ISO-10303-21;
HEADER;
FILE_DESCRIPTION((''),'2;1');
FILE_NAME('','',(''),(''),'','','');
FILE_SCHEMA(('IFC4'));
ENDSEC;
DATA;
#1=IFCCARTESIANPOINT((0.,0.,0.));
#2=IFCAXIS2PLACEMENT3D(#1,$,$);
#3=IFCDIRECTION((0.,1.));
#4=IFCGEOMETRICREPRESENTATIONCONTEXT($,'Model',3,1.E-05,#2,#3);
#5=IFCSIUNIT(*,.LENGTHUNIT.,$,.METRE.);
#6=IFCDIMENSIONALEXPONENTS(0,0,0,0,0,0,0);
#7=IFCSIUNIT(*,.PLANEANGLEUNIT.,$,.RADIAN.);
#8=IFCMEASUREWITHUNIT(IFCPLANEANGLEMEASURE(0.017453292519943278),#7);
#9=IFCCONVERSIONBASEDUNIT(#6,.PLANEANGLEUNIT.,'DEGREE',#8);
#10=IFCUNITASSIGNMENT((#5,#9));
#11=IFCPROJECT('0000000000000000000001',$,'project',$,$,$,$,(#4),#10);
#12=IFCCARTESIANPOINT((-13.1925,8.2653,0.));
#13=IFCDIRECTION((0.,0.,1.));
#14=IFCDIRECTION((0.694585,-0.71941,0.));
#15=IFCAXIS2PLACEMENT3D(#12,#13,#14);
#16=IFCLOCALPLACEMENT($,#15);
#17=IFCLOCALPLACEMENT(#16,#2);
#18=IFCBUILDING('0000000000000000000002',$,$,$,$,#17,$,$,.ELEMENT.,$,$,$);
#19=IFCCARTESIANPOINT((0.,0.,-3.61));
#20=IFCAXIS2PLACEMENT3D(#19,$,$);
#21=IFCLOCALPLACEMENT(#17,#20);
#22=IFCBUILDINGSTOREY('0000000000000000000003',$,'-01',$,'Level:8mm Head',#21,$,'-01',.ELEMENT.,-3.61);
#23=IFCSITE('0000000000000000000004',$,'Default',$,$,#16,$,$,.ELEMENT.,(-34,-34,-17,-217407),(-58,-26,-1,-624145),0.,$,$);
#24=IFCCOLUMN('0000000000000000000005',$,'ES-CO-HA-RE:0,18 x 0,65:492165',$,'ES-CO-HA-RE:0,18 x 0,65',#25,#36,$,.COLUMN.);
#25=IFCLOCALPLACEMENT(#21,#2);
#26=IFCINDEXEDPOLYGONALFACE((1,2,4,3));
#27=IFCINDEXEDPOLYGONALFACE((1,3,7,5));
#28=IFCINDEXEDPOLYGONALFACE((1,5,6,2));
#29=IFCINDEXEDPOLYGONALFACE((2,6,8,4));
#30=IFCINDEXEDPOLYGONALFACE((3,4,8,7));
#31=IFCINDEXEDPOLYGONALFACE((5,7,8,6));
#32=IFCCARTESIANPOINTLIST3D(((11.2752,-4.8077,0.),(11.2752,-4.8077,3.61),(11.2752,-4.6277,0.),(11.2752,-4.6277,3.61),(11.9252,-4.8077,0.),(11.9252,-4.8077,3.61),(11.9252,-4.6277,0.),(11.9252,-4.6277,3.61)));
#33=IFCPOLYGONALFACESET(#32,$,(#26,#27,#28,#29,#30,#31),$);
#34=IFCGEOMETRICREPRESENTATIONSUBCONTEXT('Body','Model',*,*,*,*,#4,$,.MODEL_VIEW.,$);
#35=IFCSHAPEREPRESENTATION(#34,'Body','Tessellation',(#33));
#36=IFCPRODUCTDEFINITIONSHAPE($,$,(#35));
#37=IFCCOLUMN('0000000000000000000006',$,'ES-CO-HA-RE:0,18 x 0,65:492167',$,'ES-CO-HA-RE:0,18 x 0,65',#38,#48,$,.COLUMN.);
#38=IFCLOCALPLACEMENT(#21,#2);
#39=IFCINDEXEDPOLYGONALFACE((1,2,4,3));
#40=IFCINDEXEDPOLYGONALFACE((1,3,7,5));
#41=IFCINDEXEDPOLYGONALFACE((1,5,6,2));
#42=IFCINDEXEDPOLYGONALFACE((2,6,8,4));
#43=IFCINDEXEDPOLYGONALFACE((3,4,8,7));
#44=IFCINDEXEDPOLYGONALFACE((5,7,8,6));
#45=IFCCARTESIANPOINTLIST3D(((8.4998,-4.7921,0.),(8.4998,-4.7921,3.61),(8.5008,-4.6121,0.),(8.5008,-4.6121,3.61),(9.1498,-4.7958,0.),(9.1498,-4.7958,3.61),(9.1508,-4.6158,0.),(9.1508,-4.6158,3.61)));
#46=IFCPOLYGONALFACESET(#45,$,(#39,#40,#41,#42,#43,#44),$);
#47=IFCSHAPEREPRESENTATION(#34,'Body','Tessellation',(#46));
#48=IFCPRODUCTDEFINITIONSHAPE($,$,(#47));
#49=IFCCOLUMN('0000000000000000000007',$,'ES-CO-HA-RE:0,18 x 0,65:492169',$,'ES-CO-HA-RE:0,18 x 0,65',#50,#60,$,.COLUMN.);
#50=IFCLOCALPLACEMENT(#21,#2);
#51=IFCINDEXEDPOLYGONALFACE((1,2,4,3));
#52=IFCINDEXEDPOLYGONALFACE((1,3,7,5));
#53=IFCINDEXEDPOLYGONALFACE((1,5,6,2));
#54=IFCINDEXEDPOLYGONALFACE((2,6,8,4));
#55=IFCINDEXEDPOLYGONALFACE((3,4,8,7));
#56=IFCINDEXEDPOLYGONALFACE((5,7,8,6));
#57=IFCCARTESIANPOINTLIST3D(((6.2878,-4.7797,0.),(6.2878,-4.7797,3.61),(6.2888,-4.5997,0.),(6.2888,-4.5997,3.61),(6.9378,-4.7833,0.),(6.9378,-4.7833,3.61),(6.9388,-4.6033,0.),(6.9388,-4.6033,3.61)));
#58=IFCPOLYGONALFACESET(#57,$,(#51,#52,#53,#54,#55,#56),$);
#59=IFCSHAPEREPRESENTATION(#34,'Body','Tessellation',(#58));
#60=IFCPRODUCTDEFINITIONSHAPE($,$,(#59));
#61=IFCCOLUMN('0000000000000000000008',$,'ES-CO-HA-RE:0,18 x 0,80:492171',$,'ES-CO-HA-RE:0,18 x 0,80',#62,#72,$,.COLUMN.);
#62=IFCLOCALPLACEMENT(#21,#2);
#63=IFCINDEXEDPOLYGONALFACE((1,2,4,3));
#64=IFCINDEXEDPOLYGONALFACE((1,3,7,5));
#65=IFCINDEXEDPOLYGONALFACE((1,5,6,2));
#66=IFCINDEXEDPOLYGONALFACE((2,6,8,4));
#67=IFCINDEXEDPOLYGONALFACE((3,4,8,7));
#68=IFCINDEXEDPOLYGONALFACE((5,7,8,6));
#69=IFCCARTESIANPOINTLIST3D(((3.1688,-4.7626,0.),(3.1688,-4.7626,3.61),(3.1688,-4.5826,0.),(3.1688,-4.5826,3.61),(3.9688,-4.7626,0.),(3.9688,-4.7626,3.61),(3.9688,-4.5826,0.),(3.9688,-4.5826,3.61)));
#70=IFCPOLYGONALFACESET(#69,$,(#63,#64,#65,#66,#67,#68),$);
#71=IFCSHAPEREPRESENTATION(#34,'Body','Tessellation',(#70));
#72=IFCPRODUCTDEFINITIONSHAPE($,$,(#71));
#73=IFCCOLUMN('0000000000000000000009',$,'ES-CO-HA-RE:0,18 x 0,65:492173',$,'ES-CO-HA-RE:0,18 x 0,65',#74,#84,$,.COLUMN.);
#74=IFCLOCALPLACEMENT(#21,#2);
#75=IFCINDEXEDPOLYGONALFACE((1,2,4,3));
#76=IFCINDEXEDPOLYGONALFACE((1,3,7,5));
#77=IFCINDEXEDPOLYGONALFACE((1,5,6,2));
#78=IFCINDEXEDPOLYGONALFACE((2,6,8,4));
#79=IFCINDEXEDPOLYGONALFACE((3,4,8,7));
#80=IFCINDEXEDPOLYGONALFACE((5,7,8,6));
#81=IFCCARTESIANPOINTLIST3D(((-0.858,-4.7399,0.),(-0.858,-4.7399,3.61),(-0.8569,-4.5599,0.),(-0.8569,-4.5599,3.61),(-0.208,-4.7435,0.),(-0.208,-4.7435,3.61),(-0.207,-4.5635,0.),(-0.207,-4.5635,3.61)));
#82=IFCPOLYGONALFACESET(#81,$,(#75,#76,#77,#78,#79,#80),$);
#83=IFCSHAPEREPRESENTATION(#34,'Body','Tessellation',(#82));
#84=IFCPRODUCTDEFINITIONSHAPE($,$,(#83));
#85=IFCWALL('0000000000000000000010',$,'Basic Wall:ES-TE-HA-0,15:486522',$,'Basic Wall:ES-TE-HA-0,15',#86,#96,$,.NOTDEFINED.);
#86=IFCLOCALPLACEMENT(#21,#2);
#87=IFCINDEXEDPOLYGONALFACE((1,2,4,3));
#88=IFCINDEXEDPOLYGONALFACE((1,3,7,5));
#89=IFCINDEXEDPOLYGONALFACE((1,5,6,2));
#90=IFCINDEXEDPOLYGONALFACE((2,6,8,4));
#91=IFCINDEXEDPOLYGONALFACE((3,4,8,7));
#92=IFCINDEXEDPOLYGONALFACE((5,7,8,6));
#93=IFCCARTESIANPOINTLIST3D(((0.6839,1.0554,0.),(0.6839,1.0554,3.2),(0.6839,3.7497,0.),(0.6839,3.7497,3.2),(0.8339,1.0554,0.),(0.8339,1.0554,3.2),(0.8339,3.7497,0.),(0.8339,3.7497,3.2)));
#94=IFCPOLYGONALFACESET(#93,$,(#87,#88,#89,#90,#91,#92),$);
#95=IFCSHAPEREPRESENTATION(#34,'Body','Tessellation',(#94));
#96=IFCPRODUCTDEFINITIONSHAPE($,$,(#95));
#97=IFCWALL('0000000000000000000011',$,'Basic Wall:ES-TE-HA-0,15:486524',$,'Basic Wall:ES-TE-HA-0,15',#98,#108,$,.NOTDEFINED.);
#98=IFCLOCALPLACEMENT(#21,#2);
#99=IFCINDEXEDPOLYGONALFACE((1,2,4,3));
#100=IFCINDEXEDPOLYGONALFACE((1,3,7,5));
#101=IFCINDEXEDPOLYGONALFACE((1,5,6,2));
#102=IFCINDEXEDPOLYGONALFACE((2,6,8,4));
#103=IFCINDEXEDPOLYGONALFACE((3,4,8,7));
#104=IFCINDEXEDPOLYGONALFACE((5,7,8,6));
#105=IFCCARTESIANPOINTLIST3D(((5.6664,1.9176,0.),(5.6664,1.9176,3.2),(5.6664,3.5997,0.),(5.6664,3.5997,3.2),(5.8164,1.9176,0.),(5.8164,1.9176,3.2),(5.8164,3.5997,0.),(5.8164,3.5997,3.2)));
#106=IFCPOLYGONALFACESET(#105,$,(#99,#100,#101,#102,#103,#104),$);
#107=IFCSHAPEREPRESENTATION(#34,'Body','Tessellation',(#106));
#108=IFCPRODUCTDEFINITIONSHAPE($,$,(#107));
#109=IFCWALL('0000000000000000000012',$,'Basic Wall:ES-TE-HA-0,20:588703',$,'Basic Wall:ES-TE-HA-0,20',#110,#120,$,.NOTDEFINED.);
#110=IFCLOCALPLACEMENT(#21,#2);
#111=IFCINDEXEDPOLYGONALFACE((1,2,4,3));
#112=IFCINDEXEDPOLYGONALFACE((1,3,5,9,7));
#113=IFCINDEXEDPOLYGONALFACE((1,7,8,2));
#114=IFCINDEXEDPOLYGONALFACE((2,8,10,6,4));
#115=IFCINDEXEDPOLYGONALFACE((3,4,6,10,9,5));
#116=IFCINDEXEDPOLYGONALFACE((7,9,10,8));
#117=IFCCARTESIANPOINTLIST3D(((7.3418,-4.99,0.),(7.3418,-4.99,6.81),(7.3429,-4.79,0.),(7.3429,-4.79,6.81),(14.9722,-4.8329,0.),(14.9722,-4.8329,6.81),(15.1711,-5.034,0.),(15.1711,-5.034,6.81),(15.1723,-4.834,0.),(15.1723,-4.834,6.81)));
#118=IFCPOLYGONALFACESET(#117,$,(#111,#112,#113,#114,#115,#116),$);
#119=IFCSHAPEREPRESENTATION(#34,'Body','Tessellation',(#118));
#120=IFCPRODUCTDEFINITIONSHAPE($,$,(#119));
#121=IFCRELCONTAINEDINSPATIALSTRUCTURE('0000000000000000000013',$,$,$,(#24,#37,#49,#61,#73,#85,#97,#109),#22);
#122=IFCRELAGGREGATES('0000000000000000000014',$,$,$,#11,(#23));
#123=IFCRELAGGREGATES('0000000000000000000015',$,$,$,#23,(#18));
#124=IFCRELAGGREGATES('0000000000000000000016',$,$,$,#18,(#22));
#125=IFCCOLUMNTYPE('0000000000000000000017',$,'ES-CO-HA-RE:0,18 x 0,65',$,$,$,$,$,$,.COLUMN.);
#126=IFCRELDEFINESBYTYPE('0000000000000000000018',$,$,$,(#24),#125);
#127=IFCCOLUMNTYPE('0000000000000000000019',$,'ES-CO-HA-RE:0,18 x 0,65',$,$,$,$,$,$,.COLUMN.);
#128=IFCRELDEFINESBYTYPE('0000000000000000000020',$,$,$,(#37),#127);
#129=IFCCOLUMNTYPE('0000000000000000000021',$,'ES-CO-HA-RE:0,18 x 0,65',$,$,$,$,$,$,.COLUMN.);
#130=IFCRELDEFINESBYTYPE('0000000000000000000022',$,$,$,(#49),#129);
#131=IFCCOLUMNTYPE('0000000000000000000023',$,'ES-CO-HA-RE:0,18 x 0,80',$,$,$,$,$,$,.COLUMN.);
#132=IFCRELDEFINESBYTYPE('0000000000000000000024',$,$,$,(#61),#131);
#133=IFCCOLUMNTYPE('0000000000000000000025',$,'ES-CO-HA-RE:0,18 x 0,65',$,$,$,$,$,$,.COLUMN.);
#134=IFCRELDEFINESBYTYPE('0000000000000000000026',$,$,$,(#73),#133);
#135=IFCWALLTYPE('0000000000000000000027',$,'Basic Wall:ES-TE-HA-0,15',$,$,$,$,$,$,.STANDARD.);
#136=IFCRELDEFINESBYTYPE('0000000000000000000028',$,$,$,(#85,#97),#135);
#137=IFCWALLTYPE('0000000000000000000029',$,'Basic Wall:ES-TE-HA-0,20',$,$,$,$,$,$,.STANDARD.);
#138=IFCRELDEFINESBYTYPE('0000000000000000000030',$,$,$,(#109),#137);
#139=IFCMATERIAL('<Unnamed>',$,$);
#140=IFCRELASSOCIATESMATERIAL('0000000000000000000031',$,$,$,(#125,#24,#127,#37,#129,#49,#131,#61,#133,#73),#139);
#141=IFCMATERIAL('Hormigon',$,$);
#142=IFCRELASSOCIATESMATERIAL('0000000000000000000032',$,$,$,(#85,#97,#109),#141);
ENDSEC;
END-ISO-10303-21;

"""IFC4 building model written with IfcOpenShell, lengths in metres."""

from ifc_helpers import new_model, entity, si_unit, converted_unit, direction, frame, origin, place, context, subcontext, project, spatial, indexed_curve, outline, extrude, source, transform, mapped, material, type_object, type_shapes, element, save


model = new_model("IFC4")

# Units and contexts
model_context_1 = context("Model", 3, precision=1e-05, world=origin(), true_north=direction((0.0, 1.0)))
body_context_1 = subcontext(model_context_1, "Body", "Model", "MODEL_VIEW")
ifc_project = project(units=[si_unit("LENGTHUNIT", "METRE"), converted_unit("PLANEANGLEUNIT", "DEGREE", entity("IfcPlaneAngleMeasure", 0.017453292519943278), si_unit("PLANEANGLEUNIT", "RADIAN"), dimensions=[0, 0, 0, 0, 0, 0, 0])], contexts=[model_context_1])

# Site, building, storey
site_placement = place(None, frame((-13.1925, 8.2653, 0.0), z_axis=(0.0, 0.0, 1.0), x_axis=(0.694585, -0.71941, 0.0)))
site = spatial("IfcSite", under=ifc_project, at=site_placement, Name="Default", CompositionType="ELEMENT", RefLatitude=(-34, -34, -17, -217407), RefLongitude=(-58, -26, -1, -624145), RefElevation=0.0)
building_placement = place(site_placement, origin())
building = spatial("IfcBuilding", under=site, at=building_placement, CompositionType="ELEMENT")
storey_placement = place(building_placement, frame((0.0, 0.0, -3.61)))
storey = spatial("IfcBuildingStorey", under=building, at=storey_placement, Name="-01", ObjectType="Level:8mm Head", LongName="-01", CompositionType="ELEMENT", Elevation=-3.61)

# Columns
ifc_material_1 = material(Name="<Unnamed>")
column_type_1 = type_object("IfcColumnType", Name="ES-CO-HA-RE:0,18 x 0,65", PredefinedType="COLUMN", material=ifc_material_1)
shared_shape_1 = source(origin(), body_context_1, "Body", "SweptSolid", [
    extrude(outline(indexed_curve([(-0.325, -0.09), (0.325, -0.09), (0.325, 0.09), (-0.325, 0.09), (-0.325, -0.09)], self_intersect=False)), frame((11.6002, -4.7177, -3.61), z_axis=(0.0, 0.0, 1.0), x_axis=(-1.0, 0.0, 0.0)), (0.0, 0.0, 1.0), 3.61),
])
type_shapes(column_type_1, [shared_shape_1])
column_1_placement = place(storey_placement, frame((0.0, 0.0, 3.61)))
element("IfcColumn", 1, at=column_1_placement, inside=storey, type_object=column_type_1, material=ifc_material_1, Name="ES-CO-HA-RE:0,18 x 0,65:492165", ObjectType="ES-CO-HA-RE:0,18 x 0,65", PredefinedType="COLUMN", context=body_context_1, shape_type="MappedRepresentation", body=[
    mapped(shared_shape_1, transform((0.0, 0.0, 0.0), scale=1.0)),
])
column_type_2 = type_object("IfcColumnType", Name="ES-CO-HA-RE:0,18 x 0,65", PredefinedType="COLUMN", material=ifc_material_1)
shared_shape_2 = source(origin(), body_context_1, "Body", "SweptSolid", [
    extrude(outline(indexed_curve([(-0.325, -0.09), (0.325, -0.09), (0.325, 0.09), (-0.325, 0.09), (-0.325, -0.09)], self_intersect=False)), frame((8.8253, -4.7039, -3.61), z_axis=(0.0, 0.0, 1.0), x_axis=(-0.999984, 0.005619, 0.0)), (0.0, 0.0, 1.0), 3.61),
])
type_shapes(column_type_2, [shared_shape_2])
column_2_placement = place(storey_placement, frame((0.0, 0.0, 3.61)))
element("IfcColumn", 2, at=column_2_placement, inside=storey, type_object=column_type_2, material=ifc_material_1, Name="ES-CO-HA-RE:0,18 x 0,65:492167", ObjectType="ES-CO-HA-RE:0,18 x 0,65", PredefinedType="COLUMN", context=body_context_1, shape_type="MappedRepresentation", body=[
    mapped(shared_shape_2, transform((0.0, 0.0, 0.0), scale=1.0)),
])
column_type_3 = type_object("IfcColumnType", Name="ES-CO-HA-RE:0,18 x 0,65", PredefinedType="COLUMN", material=ifc_material_1)
shared_shape_3 = source(origin(), body_context_1, "Body", "SweptSolid", [
    extrude(outline(indexed_curve([(-0.325, -0.09), (0.325, -0.09), (0.325, 0.09), (-0.325, 0.09), (-0.325, -0.09)], self_intersect=False)), frame((6.6133, -4.6915, -3.61), z_axis=(0.0, 0.0, 1.0), x_axis=(-0.999984, 0.005624, 0.0)), (0.0, 0.0, 1.0), 3.61),
])
type_shapes(column_type_3, [shared_shape_3])
column_3_placement = place(storey_placement, frame((0.0, 0.0, 3.61)))
element("IfcColumn", 3, at=column_3_placement, inside=storey, type_object=column_type_3, material=ifc_material_1, Name="ES-CO-HA-RE:0,18 x 0,65:492169", ObjectType="ES-CO-HA-RE:0,18 x 0,65", PredefinedType="COLUMN", context=body_context_1, shape_type="MappedRepresentation", body=[
    mapped(shared_shape_3, transform((0.0, 0.0, 0.0), scale=1.0)),
])
column_type_4 = type_object("IfcColumnType", Name="ES-CO-HA-RE:0,18 x 0,80", PredefinedType="COLUMN", material=ifc_material_1)
shared_shape_4 = source(origin(), body_context_1, "Body", "SweptSolid", [
    extrude(outline(indexed_curve([(-0.4, -0.09), (0.4, -0.09), (0.4, 0.09), (-0.4, 0.09), (-0.4, -0.09)], self_intersect=False)), frame((3.5688, -4.6726, -3.61), z_axis=(0.0, 0.0, 1.0), x_axis=(-1.0, 0.0, 0.0)), (0.0, 0.0, 1.0), 3.61),
])
type_shapes(column_type_4, [shared_shape_4])
column_4_placement = place(storey_placement, frame((0.0, 0.0, 3.61)))
element("IfcColumn", 4, at=column_4_placement, inside=storey, type_object=column_type_4, material=ifc_material_1, Name="ES-CO-HA-RE:0,18 x 0,80:492171", ObjectType="ES-CO-HA-RE:0,18 x 0,80", PredefinedType="COLUMN", context=body_context_1, shape_type="MappedRepresentation", body=[
    mapped(shared_shape_4, transform((0.0, 0.0, 0.0), scale=1.0)),
])
column_type_5 = type_object("IfcColumnType", Name="ES-CO-HA-RE:0,18 x 0,65", PredefinedType="COLUMN", material=ifc_material_1)
shared_shape_5 = source(origin(), body_context_1, "Body", "SweptSolid", [
    extrude(outline(indexed_curve([(-0.325, -0.09), (0.325, -0.09), (0.325, 0.09), (-0.325, 0.09), (-0.325, -0.09)], self_intersect=False)), frame((-0.5325, -4.6517, -3.61), z_axis=(0.0, 0.0, 1.0), x_axis=(-0.999984, 0.005624, 0.0)), (0.0, 0.0, 1.0), 3.61),
])
type_shapes(column_type_5, [shared_shape_5])
column_5_placement = place(storey_placement, frame((0.0, 0.0, 3.61)))
element("IfcColumn", 5, at=column_5_placement, inside=storey, type_object=column_type_5, material=ifc_material_1, Name="ES-CO-HA-RE:0,18 x 0,65:492173", ObjectType="ES-CO-HA-RE:0,18 x 0,65", PredefinedType="COLUMN", context=body_context_1, shape_type="MappedRepresentation", body=[
    mapped(shared_shape_5, transform((0.0, 0.0, 0.0), scale=1.0)),
])

# Walls
ifc_material_2 = material(Name="Hormigon")
wall_type_1 = type_object("IfcWallType", Name="Basic Wall:ES-TE-HA-0,15", PredefinedType="STANDARD")
wall_1_placement = place(storey_placement, frame((0.7589, 1.0554, 0.0), z_axis=(0.0, 0.0, 1.0), x_axis=(0.0, 1.0, 0.0)))
element("IfcWall", 6, at=wall_1_placement, inside=storey, type_object=wall_type_1, material=ifc_material_2, Name="Basic Wall:ES-TE-HA-0,15:486522", ObjectType="Basic Wall:ES-TE-HA-0,15", PredefinedType="NOTDEFINED", context=body_context_1, shape_type="SweptSolid", body=[
    extrude(outline(indexed_curve([(2.6942, 0.075), (0.0, 0.075), (0.0, -0.075), (2.6942, -0.075), (2.6942, 0.075)], self_intersect=False)), origin(), (0.0, 0.0, 1.0), 3.2),
])
wall_2_placement = place(storey_placement, frame((5.7414, 1.9176, 0.0), z_axis=(0.0, 0.0, 1.0), x_axis=(0.0, 1.0, 0.0)))
element("IfcWall", 7, at=wall_2_placement, inside=storey, type_object=wall_type_1, material=ifc_material_2, Name="Basic Wall:ES-TE-HA-0,15:486524", ObjectType="Basic Wall:ES-TE-HA-0,15", PredefinedType="NOTDEFINED", context=body_context_1, shape_type="SweptSolid", body=[
    extrude(outline(indexed_curve([(1.682, 0.075), (0.0, 0.075), (0.0, -0.075), (1.682, -0.075), (1.682, 0.075)], self_intersect=False)), origin(), (0.0, 0.0, 1.0), 3.2),
])
wall_type_2 = type_object("IfcWallType", Name="Basic Wall:ES-TE-HA-0,20", PredefinedType="STANDARD")

# Wall
wall_3_placement = place(storey_placement, frame((15.1717, -4.934, 0.0), z_axis=(0.0, 0.0, 1.0), x_axis=(-0.999984, 0.005619, 0.0)))
element("IfcWall", 8, at=wall_3_placement, inside=storey, type_object=wall_type_2, material=ifc_material_2, Name="Basic Wall:ES-TE-HA-0,20:588703", ObjectType="Basic Wall:ES-TE-HA-0,20", PredefinedType="NOTDEFINED", context=body_context_1, shape_type="SweptSolid", body=[
    extrude(outline(indexed_curve([(0.0, 0.1), (0.0, -0.1), (0.2, -0.1), (7.8295, -0.1), (7.8295, 0.1), (0.0, 0.1)], self_intersect=False)), origin(), (0.0, 0.0, 1.0), 6.81),
])

save(model, "model.ifc")
